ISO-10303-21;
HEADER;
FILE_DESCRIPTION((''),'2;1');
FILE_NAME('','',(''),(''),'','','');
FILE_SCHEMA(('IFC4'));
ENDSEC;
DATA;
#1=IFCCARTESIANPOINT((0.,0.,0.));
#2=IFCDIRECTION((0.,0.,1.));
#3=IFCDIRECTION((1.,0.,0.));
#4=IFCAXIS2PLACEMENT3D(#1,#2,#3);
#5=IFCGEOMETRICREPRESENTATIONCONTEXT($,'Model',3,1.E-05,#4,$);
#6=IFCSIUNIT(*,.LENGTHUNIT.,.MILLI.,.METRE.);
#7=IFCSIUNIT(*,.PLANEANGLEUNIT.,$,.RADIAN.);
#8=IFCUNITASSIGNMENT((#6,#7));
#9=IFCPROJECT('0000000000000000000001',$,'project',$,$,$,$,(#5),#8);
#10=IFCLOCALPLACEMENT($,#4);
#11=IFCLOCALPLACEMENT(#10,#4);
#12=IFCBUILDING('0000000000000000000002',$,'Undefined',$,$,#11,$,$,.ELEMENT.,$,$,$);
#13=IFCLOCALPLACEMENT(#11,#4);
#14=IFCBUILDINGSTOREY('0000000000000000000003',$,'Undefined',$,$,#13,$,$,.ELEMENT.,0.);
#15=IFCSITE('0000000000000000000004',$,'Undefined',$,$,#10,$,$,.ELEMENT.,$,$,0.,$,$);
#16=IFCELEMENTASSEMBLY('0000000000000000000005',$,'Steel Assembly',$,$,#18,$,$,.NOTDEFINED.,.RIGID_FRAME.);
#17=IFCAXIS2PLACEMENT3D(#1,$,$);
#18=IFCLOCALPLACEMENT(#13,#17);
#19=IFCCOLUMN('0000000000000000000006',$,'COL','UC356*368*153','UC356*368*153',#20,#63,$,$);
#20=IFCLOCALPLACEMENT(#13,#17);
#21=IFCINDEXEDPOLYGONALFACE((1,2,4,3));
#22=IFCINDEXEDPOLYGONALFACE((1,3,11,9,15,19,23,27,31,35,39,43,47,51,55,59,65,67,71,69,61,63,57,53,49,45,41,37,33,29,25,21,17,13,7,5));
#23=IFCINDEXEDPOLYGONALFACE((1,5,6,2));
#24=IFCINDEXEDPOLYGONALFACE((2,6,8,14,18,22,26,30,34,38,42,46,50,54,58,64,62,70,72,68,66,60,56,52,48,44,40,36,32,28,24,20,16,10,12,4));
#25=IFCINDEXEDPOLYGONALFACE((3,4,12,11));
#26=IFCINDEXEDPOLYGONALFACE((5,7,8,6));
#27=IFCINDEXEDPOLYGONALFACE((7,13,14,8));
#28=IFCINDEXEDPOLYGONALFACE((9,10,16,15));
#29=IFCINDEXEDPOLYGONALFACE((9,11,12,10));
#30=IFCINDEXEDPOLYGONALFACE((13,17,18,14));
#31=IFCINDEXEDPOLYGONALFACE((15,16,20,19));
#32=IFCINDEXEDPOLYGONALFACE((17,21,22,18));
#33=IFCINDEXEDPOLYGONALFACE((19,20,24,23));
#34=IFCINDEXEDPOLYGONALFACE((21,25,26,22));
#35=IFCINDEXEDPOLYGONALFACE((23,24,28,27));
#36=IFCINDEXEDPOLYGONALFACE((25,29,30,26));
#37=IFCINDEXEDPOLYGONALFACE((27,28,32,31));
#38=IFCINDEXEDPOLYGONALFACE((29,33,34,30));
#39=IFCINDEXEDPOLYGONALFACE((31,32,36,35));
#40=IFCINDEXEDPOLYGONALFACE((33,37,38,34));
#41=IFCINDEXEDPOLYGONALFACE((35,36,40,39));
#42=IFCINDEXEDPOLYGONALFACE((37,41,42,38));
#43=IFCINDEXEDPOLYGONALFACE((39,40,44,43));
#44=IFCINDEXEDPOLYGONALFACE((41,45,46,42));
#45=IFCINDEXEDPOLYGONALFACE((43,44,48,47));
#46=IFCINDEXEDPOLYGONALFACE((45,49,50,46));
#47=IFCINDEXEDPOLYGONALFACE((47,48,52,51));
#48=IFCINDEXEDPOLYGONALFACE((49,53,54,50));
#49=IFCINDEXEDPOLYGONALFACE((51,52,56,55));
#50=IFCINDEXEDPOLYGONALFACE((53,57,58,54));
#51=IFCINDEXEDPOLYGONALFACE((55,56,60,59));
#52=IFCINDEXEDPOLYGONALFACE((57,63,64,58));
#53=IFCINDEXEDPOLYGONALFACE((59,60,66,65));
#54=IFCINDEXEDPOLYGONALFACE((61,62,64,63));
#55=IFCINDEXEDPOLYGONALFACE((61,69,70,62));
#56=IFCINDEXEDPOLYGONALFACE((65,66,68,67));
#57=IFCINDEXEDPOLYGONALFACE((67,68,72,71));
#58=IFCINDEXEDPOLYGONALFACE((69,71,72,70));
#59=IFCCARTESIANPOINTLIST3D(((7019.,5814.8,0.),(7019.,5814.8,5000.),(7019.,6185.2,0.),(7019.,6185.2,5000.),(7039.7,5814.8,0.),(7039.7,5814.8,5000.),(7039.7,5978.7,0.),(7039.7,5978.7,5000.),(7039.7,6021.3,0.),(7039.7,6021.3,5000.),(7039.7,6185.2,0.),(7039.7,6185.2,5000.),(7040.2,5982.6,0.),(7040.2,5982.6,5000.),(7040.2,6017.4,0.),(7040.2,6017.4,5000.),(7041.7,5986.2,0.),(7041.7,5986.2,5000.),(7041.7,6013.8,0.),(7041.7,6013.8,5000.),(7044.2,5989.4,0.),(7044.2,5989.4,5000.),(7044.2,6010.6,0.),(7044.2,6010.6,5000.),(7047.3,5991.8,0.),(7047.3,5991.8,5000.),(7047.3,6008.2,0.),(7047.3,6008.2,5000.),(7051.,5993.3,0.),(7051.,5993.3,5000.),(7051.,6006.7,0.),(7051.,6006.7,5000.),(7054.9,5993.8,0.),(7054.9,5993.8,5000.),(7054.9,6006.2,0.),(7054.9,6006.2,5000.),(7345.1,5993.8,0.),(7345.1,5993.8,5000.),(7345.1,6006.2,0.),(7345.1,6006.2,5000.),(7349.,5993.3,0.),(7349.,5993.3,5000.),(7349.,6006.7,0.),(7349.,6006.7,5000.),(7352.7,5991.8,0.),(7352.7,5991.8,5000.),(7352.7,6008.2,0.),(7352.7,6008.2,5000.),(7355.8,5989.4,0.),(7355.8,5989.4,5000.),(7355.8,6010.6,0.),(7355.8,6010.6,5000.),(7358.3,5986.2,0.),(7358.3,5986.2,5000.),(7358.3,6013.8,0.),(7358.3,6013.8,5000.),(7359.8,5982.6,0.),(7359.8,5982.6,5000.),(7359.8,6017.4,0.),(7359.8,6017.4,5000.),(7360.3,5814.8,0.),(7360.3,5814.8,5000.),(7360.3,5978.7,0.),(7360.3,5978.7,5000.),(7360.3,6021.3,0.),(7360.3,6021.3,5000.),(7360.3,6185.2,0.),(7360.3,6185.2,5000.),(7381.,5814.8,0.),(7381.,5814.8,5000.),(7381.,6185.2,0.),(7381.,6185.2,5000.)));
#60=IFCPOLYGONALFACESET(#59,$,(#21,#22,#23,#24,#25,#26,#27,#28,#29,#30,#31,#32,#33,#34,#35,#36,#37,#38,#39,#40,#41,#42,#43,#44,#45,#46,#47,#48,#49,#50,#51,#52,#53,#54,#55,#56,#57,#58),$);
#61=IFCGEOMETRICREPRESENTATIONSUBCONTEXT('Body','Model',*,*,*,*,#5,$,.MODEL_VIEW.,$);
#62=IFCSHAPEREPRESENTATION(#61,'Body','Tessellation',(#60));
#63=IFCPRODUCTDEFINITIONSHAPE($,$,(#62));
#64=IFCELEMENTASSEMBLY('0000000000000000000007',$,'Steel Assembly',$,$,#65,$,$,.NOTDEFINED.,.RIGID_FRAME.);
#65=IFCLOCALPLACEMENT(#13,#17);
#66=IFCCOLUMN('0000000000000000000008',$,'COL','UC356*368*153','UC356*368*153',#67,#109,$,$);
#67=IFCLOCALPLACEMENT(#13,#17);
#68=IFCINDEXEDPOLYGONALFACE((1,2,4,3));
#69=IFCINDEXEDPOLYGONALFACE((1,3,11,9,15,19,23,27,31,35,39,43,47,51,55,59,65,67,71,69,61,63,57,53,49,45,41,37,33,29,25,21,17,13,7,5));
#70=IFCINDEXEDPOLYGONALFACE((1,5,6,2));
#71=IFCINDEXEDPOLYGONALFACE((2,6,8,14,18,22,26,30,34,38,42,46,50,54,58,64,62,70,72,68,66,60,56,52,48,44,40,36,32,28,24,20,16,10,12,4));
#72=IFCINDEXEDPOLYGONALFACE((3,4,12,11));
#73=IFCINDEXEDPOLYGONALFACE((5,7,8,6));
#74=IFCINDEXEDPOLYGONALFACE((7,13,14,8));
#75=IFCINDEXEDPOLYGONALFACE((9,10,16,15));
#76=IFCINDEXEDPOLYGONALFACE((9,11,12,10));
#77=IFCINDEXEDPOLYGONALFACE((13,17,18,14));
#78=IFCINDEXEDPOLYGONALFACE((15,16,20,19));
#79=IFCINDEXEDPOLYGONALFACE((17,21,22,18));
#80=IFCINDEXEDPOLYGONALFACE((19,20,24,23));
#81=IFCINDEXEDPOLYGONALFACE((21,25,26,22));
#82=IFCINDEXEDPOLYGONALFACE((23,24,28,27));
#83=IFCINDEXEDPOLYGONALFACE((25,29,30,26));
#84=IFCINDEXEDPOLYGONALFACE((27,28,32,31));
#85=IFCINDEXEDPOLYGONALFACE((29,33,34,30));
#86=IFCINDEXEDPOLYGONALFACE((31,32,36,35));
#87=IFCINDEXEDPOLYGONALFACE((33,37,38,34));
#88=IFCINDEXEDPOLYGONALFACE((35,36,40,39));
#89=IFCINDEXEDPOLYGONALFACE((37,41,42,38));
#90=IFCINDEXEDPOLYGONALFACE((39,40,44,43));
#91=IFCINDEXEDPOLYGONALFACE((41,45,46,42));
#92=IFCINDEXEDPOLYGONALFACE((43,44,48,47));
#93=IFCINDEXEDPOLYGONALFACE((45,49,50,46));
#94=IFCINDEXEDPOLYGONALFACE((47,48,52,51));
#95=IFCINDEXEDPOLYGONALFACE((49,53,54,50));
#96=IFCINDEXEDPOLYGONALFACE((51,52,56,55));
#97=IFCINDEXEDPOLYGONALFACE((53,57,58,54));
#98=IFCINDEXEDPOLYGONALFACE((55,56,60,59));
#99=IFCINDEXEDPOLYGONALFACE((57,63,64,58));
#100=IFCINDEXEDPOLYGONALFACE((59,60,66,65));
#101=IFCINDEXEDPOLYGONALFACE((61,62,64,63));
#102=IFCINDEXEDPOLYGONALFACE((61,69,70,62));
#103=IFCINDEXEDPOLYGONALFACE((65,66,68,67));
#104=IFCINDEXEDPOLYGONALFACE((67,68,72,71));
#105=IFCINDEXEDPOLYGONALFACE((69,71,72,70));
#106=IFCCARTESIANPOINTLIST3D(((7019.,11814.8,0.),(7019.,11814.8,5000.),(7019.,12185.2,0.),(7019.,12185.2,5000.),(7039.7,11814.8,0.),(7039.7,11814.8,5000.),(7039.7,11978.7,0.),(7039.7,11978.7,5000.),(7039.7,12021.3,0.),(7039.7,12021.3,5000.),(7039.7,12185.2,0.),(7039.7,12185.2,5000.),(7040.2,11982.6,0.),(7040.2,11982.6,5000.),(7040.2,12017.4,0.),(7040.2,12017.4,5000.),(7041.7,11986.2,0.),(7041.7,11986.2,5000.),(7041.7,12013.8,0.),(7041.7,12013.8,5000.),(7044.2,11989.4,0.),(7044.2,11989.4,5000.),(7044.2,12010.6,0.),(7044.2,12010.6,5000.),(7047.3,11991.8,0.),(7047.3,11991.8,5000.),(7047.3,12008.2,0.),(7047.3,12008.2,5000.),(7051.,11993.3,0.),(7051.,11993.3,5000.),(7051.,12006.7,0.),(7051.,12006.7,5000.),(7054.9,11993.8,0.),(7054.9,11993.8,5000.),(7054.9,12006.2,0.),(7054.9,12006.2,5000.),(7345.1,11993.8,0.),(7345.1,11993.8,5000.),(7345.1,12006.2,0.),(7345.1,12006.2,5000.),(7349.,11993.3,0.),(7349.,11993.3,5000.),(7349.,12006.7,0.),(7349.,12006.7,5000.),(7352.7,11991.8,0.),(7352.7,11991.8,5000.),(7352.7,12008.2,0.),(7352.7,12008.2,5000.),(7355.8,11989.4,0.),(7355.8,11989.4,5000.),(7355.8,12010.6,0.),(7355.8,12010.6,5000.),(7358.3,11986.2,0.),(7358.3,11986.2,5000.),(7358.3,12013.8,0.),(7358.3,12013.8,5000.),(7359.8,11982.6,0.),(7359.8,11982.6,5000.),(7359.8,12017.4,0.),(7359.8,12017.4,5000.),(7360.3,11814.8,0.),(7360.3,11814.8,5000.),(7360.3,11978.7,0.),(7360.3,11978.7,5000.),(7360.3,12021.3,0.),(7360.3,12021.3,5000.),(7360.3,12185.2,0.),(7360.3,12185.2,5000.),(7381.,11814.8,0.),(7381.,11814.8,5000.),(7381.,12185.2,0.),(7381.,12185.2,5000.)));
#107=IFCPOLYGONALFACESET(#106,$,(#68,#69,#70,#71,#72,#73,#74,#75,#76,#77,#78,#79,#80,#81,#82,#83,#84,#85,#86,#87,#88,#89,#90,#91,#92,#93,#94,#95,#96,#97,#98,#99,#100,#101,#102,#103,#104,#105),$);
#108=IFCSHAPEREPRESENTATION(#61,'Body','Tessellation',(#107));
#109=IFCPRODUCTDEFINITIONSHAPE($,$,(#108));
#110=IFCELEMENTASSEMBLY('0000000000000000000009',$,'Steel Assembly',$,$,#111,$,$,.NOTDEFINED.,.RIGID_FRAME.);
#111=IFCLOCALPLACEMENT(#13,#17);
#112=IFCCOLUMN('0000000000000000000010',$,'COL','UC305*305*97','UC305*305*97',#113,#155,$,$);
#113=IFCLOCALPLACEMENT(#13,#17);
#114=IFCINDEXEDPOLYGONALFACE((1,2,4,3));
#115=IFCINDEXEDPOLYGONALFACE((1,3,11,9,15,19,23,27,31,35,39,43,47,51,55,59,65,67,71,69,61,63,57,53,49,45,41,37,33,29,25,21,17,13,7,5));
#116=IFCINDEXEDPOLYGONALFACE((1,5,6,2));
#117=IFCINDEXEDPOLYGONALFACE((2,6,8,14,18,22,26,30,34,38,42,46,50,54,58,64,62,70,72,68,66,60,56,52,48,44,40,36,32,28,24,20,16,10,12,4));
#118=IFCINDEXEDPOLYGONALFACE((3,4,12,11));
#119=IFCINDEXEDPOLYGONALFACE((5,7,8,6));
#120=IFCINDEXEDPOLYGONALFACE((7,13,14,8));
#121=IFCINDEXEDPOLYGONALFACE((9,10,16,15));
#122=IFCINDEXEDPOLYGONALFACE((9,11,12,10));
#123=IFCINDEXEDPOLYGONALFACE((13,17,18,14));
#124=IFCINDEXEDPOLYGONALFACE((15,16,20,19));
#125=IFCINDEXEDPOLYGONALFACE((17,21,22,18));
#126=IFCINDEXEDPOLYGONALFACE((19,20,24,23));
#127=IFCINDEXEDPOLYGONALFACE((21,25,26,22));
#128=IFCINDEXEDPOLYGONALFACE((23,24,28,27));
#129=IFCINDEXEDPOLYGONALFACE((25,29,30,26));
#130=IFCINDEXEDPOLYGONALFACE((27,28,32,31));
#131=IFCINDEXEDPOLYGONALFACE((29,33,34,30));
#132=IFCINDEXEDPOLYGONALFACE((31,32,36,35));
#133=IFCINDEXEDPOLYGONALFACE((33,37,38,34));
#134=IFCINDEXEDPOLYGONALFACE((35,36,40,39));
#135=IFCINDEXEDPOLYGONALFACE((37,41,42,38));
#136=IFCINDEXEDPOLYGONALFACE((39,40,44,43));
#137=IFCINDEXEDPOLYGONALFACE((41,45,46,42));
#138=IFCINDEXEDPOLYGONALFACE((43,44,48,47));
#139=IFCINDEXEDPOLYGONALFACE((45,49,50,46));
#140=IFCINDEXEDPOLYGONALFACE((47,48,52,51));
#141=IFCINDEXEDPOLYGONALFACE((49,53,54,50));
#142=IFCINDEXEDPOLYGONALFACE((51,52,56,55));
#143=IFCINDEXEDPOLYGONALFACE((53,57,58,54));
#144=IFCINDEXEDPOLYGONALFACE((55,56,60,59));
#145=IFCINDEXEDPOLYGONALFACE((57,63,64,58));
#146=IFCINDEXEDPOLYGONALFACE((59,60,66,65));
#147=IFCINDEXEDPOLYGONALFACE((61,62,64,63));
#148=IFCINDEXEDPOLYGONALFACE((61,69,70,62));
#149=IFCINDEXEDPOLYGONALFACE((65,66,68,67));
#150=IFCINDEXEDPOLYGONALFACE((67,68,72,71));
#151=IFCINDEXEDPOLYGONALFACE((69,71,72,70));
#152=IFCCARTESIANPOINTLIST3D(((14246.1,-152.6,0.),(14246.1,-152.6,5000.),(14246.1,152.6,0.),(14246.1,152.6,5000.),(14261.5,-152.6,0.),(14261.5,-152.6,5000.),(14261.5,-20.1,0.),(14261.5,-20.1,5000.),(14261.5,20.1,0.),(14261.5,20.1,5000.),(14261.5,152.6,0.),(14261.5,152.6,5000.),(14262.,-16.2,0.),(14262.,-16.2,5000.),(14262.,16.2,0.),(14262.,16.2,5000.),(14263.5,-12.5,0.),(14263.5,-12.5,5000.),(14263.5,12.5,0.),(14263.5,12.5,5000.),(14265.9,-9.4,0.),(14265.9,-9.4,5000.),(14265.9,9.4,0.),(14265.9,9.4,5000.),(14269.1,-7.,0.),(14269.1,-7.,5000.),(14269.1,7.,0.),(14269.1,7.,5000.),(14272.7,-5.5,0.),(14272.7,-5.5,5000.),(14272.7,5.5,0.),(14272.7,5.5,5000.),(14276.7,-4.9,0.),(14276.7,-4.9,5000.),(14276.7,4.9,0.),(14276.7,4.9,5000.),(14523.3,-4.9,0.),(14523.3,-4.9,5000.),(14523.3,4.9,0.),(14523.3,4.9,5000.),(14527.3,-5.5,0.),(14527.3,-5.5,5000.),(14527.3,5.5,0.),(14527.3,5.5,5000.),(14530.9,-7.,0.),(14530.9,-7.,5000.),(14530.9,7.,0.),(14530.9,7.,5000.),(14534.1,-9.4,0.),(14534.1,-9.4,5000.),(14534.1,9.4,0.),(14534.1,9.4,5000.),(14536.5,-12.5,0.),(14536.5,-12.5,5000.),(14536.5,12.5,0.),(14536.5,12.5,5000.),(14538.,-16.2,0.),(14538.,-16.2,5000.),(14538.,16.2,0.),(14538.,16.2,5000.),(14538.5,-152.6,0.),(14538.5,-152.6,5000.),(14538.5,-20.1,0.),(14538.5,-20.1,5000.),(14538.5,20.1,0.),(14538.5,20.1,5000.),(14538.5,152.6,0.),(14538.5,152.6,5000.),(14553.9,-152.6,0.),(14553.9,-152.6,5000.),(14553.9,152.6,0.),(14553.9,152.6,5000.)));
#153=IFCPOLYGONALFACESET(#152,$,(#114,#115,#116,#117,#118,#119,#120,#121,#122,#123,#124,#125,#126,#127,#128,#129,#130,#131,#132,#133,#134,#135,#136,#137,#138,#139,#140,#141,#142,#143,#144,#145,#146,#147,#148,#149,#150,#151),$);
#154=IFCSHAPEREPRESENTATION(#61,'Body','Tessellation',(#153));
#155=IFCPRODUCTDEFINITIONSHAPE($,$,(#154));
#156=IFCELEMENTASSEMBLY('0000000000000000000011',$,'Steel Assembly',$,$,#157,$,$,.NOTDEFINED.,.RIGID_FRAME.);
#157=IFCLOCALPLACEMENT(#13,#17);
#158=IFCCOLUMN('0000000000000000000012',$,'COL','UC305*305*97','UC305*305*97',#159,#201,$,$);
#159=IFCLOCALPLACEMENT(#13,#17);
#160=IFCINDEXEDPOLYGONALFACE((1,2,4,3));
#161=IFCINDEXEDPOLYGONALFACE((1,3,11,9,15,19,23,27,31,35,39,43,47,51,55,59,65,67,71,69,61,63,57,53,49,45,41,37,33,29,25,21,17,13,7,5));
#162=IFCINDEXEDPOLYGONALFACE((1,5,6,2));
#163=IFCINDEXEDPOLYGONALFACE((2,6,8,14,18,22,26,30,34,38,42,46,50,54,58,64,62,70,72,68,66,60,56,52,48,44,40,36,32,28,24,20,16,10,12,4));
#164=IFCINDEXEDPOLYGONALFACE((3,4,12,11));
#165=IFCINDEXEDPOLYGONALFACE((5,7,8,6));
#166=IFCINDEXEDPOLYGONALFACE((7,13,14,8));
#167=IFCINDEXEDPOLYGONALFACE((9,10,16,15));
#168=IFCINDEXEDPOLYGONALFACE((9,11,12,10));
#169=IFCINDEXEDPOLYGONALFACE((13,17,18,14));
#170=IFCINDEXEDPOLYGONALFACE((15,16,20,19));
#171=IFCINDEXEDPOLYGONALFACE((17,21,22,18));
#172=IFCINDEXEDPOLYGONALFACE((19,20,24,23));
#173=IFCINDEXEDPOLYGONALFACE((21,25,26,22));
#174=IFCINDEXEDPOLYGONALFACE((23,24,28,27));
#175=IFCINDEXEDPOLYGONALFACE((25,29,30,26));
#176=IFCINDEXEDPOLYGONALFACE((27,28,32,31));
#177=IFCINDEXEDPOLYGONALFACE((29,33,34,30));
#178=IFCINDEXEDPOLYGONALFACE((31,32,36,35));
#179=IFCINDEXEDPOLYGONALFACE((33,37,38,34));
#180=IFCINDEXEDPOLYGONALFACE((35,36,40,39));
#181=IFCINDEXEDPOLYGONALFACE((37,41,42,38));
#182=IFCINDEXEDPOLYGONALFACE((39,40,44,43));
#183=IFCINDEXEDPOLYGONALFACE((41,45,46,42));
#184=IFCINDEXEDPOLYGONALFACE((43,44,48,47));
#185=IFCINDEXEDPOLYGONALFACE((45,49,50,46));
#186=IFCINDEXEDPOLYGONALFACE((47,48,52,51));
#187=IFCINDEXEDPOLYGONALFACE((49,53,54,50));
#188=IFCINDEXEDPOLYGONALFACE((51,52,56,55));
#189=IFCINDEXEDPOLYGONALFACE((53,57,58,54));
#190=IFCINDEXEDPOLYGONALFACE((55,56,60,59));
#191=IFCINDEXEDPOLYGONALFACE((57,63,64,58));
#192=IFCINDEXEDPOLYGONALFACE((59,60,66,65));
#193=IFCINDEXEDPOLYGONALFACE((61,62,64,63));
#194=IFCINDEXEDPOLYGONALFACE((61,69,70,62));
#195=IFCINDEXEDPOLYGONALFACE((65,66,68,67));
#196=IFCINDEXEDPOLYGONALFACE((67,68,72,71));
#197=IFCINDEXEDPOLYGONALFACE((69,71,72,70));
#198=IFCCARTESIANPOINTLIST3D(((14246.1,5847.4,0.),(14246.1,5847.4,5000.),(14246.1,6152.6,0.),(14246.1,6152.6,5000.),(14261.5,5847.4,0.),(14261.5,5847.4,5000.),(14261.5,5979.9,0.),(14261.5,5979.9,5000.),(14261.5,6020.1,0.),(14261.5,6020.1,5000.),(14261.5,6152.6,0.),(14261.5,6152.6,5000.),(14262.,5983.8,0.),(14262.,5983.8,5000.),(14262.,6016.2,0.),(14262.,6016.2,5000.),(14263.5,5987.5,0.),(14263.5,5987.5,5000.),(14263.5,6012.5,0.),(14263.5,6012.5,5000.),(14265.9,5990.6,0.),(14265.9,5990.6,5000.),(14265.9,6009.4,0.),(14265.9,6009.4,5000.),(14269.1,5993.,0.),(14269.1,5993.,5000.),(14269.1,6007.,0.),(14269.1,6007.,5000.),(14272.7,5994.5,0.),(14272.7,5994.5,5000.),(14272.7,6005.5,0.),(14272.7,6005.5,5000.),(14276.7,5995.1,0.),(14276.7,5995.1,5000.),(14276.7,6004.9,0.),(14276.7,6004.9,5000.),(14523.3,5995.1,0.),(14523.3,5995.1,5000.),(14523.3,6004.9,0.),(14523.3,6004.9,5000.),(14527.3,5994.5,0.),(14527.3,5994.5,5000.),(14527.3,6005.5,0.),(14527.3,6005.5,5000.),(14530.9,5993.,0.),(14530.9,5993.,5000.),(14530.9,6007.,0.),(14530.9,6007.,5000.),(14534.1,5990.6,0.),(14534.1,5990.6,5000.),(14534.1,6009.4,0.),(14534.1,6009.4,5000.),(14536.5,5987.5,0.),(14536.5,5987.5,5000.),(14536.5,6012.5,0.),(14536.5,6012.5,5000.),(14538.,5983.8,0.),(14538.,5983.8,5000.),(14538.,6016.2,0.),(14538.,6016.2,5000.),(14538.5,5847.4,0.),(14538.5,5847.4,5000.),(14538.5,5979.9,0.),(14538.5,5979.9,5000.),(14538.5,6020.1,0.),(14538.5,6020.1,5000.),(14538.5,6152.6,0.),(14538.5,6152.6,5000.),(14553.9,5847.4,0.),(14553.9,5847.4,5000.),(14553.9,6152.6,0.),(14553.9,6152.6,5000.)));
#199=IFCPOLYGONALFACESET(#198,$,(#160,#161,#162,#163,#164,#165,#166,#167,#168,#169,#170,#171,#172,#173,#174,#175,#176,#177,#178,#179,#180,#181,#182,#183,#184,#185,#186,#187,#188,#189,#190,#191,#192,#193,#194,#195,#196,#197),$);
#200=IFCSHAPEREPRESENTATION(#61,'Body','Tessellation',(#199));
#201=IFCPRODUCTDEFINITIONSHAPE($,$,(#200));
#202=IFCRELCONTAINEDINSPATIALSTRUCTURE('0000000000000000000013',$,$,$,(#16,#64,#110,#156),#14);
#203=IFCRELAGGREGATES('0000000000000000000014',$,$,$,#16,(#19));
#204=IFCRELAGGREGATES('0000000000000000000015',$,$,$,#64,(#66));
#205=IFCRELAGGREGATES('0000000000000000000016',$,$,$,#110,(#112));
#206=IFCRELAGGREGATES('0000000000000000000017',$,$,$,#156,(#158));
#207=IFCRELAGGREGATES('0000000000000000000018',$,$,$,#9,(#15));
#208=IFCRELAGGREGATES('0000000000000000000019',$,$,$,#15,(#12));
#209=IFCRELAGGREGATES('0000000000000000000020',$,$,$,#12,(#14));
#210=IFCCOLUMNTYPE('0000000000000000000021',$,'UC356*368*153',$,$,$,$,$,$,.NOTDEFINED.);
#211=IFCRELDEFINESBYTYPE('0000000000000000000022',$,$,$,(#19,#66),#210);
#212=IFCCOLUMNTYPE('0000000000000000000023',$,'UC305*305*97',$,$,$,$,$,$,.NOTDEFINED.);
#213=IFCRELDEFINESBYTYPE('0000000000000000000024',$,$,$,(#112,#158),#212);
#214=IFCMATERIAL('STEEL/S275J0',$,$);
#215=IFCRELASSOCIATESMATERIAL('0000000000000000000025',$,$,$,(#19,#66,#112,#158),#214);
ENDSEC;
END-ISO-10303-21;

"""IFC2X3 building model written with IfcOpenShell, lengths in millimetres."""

from ifc_helpers import new_model, si_unit, frame, origin_with_axes, origin_2d_with_axis, place, context, subcontext, project, spatial, i_section, extrude, material, type_object, element, aggregate, save


model = new_model("IFC2X3")

# Units and contexts
model_context = context("Model", 3, precision=1e-05, world=origin_with_axes())
body_context = subcontext(model_context, "Body", "Model", "MODEL_VIEW")
ifc_project = project(units=[si_unit("LENGTHUNIT", "METRE", prefix="MILLI"), si_unit("PLANEANGLEUNIT", "RADIAN")], contexts=[model_context])

# Site, building, storey
site_placement = place(None, origin_with_axes())
site = spatial("IfcSite", under=ifc_project, at=site_placement, Name="Undefined", CompositionType="ELEMENT", RefElevation=0.0)
building_placement = place(site_placement, origin_with_axes())
building = spatial("IfcBuilding", under=site, at=building_placement, Name="Undefined", CompositionType="ELEMENT")
storey_placement = place(building_placement, origin_with_axes())
storey = spatial("IfcBuildingStorey", under=building, at=storey_placement, Name="Undefined", CompositionType="ELEMENT", Elevation=0.0)

# Element assemblies, columns
ifc_material = material(Name="STEEL/S275J0")
column_type_1 = type_object("IfcColumnType", Name="UC356*368*153", PredefinedType="NOTDEFINED")
assembly_1_placement = place(storey_placement, origin_with_axes())
assembly_1 = element("IfcElementAssembly", 1, at=assembly_1_placement, inside=storey, Name="Steel Assembly", AssemblyPlace="NOTDEFINED", PredefinedType="RIGID_FRAME")
column_1_placement = place(assembly_1_placement, frame((7200.0, 6000.0, 0.0), z_axis=(0.0, 0.0, 1.0), x_axis=(1.0, 0.0, 0.0)))
column_1 = element("IfcColumn", 2, at=column_1_placement, type_object=column_type_1, material=ifc_material, Name="COL", Description="UC356*368*153", ObjectType="UC356*368*153", context=body_context, shape_type="SweptSolid", body=[
    extrude(i_section(OverallWidth=370.5, OverallDepth=362.0, WebThickness=12.3, FlangeThickness=20.7, FilletRadius=15.2, at=origin_2d_with_axis()), frame((0.0, 0.0, 5000.0), z_axis=(0.0, 0.0, -1.0), x_axis=(0.0, -1.0, 0.0)), (0.0, 0.0, 1.0), 5000.0),
])
aggregate(assembly_1, [column_1])
assembly_2_placement = place(storey_placement, origin_with_axes())
assembly_2 = element("IfcElementAssembly", 3, at=assembly_2_placement, inside=storey, Name="Steel Assembly", AssemblyPlace="NOTDEFINED", PredefinedType="RIGID_FRAME")
column_2_placement = place(assembly_2_placement, frame((7200.0, 12000.0, 0.0), z_axis=(0.0, 0.0, 1.0), x_axis=(1.0, 0.0, 0.0)))
column_2 = element("IfcColumn", 4, at=column_2_placement, type_object=column_type_1, material=ifc_material, Name="COL", Description="UC356*368*153", ObjectType="UC356*368*153", context=body_context, shape_type="SweptSolid", body=[
    extrude(i_section(OverallWidth=370.5, OverallDepth=362.0, WebThickness=12.3, FlangeThickness=20.7, FilletRadius=15.2, at=origin_2d_with_axis()), frame((0.0, 0.0, 5000.0), z_axis=(0.0, 0.0, -1.0), x_axis=(0.0, -1.0, 0.0)), (0.0, 0.0, 1.0), 5000.0),
])
aggregate(assembly_2, [column_2])
assembly_3_placement = place(storey_placement, origin_with_axes())
assembly_3 = element("IfcElementAssembly", 5, at=assembly_3_placement, inside=storey, Name="Steel Assembly", AssemblyPlace="NOTDEFINED", PredefinedType="RIGID_FRAME")
column_type_2 = type_object("IfcColumnType", Name="UC305*305*97", PredefinedType="NOTDEFINED")
column_3_placement = place(assembly_3_placement, frame((14400.0, 0.0, 0.0), z_axis=(0.0, 0.0, 1.0), x_axis=(1.0, 0.0, 0.0)))
column_3 = element("IfcColumn", 6, at=column_3_placement, type_object=column_type_2, material=ifc_material, Name="COL", Description="UC305*305*97", ObjectType="UC305*305*97", context=body_context, shape_type="SweptSolid", body=[
    extrude(i_section(OverallWidth=305.3, OverallDepth=307.9, WebThickness=9.9, FlangeThickness=15.4, FilletRadius=15.2, at=origin_2d_with_axis()), frame((0.0, 0.0, 5000.0), z_axis=(0.0, 0.0, -1.0), x_axis=(0.0, -1.0, 0.0)), (0.0, 0.0, 1.0), 5000.0),
])
aggregate(assembly_3, [column_3])
assembly_4_placement = place(storey_placement, origin_with_axes())
assembly_4 = element("IfcElementAssembly", 7, at=assembly_4_placement, inside=storey, Name="Steel Assembly", AssemblyPlace="NOTDEFINED", PredefinedType="RIGID_FRAME")
column_4_placement = place(assembly_4_placement, frame((14400.0, 6000.0, 0.0), z_axis=(0.0, 0.0, 1.0), x_axis=(1.0, 0.0, 0.0)))
column_4 = element("IfcColumn", 8, at=column_4_placement, type_object=column_type_2, material=ifc_material, Name="COL", Description="UC305*305*97", ObjectType="UC305*305*97", context=body_context, shape_type="SweptSolid", body=[
    extrude(i_section(OverallWidth=305.3, OverallDepth=307.9, WebThickness=9.9, FlangeThickness=15.4, FilletRadius=15.2, at=origin_2d_with_axis()), frame((0.0, 0.0, 5000.0), z_axis=(0.0, 0.0, -1.0), x_axis=(0.0, -1.0, 0.0)), (0.0, 0.0, 1.0), 5000.0),
])
aggregate(assembly_4, [column_4])

save(model, "model.ifc")
